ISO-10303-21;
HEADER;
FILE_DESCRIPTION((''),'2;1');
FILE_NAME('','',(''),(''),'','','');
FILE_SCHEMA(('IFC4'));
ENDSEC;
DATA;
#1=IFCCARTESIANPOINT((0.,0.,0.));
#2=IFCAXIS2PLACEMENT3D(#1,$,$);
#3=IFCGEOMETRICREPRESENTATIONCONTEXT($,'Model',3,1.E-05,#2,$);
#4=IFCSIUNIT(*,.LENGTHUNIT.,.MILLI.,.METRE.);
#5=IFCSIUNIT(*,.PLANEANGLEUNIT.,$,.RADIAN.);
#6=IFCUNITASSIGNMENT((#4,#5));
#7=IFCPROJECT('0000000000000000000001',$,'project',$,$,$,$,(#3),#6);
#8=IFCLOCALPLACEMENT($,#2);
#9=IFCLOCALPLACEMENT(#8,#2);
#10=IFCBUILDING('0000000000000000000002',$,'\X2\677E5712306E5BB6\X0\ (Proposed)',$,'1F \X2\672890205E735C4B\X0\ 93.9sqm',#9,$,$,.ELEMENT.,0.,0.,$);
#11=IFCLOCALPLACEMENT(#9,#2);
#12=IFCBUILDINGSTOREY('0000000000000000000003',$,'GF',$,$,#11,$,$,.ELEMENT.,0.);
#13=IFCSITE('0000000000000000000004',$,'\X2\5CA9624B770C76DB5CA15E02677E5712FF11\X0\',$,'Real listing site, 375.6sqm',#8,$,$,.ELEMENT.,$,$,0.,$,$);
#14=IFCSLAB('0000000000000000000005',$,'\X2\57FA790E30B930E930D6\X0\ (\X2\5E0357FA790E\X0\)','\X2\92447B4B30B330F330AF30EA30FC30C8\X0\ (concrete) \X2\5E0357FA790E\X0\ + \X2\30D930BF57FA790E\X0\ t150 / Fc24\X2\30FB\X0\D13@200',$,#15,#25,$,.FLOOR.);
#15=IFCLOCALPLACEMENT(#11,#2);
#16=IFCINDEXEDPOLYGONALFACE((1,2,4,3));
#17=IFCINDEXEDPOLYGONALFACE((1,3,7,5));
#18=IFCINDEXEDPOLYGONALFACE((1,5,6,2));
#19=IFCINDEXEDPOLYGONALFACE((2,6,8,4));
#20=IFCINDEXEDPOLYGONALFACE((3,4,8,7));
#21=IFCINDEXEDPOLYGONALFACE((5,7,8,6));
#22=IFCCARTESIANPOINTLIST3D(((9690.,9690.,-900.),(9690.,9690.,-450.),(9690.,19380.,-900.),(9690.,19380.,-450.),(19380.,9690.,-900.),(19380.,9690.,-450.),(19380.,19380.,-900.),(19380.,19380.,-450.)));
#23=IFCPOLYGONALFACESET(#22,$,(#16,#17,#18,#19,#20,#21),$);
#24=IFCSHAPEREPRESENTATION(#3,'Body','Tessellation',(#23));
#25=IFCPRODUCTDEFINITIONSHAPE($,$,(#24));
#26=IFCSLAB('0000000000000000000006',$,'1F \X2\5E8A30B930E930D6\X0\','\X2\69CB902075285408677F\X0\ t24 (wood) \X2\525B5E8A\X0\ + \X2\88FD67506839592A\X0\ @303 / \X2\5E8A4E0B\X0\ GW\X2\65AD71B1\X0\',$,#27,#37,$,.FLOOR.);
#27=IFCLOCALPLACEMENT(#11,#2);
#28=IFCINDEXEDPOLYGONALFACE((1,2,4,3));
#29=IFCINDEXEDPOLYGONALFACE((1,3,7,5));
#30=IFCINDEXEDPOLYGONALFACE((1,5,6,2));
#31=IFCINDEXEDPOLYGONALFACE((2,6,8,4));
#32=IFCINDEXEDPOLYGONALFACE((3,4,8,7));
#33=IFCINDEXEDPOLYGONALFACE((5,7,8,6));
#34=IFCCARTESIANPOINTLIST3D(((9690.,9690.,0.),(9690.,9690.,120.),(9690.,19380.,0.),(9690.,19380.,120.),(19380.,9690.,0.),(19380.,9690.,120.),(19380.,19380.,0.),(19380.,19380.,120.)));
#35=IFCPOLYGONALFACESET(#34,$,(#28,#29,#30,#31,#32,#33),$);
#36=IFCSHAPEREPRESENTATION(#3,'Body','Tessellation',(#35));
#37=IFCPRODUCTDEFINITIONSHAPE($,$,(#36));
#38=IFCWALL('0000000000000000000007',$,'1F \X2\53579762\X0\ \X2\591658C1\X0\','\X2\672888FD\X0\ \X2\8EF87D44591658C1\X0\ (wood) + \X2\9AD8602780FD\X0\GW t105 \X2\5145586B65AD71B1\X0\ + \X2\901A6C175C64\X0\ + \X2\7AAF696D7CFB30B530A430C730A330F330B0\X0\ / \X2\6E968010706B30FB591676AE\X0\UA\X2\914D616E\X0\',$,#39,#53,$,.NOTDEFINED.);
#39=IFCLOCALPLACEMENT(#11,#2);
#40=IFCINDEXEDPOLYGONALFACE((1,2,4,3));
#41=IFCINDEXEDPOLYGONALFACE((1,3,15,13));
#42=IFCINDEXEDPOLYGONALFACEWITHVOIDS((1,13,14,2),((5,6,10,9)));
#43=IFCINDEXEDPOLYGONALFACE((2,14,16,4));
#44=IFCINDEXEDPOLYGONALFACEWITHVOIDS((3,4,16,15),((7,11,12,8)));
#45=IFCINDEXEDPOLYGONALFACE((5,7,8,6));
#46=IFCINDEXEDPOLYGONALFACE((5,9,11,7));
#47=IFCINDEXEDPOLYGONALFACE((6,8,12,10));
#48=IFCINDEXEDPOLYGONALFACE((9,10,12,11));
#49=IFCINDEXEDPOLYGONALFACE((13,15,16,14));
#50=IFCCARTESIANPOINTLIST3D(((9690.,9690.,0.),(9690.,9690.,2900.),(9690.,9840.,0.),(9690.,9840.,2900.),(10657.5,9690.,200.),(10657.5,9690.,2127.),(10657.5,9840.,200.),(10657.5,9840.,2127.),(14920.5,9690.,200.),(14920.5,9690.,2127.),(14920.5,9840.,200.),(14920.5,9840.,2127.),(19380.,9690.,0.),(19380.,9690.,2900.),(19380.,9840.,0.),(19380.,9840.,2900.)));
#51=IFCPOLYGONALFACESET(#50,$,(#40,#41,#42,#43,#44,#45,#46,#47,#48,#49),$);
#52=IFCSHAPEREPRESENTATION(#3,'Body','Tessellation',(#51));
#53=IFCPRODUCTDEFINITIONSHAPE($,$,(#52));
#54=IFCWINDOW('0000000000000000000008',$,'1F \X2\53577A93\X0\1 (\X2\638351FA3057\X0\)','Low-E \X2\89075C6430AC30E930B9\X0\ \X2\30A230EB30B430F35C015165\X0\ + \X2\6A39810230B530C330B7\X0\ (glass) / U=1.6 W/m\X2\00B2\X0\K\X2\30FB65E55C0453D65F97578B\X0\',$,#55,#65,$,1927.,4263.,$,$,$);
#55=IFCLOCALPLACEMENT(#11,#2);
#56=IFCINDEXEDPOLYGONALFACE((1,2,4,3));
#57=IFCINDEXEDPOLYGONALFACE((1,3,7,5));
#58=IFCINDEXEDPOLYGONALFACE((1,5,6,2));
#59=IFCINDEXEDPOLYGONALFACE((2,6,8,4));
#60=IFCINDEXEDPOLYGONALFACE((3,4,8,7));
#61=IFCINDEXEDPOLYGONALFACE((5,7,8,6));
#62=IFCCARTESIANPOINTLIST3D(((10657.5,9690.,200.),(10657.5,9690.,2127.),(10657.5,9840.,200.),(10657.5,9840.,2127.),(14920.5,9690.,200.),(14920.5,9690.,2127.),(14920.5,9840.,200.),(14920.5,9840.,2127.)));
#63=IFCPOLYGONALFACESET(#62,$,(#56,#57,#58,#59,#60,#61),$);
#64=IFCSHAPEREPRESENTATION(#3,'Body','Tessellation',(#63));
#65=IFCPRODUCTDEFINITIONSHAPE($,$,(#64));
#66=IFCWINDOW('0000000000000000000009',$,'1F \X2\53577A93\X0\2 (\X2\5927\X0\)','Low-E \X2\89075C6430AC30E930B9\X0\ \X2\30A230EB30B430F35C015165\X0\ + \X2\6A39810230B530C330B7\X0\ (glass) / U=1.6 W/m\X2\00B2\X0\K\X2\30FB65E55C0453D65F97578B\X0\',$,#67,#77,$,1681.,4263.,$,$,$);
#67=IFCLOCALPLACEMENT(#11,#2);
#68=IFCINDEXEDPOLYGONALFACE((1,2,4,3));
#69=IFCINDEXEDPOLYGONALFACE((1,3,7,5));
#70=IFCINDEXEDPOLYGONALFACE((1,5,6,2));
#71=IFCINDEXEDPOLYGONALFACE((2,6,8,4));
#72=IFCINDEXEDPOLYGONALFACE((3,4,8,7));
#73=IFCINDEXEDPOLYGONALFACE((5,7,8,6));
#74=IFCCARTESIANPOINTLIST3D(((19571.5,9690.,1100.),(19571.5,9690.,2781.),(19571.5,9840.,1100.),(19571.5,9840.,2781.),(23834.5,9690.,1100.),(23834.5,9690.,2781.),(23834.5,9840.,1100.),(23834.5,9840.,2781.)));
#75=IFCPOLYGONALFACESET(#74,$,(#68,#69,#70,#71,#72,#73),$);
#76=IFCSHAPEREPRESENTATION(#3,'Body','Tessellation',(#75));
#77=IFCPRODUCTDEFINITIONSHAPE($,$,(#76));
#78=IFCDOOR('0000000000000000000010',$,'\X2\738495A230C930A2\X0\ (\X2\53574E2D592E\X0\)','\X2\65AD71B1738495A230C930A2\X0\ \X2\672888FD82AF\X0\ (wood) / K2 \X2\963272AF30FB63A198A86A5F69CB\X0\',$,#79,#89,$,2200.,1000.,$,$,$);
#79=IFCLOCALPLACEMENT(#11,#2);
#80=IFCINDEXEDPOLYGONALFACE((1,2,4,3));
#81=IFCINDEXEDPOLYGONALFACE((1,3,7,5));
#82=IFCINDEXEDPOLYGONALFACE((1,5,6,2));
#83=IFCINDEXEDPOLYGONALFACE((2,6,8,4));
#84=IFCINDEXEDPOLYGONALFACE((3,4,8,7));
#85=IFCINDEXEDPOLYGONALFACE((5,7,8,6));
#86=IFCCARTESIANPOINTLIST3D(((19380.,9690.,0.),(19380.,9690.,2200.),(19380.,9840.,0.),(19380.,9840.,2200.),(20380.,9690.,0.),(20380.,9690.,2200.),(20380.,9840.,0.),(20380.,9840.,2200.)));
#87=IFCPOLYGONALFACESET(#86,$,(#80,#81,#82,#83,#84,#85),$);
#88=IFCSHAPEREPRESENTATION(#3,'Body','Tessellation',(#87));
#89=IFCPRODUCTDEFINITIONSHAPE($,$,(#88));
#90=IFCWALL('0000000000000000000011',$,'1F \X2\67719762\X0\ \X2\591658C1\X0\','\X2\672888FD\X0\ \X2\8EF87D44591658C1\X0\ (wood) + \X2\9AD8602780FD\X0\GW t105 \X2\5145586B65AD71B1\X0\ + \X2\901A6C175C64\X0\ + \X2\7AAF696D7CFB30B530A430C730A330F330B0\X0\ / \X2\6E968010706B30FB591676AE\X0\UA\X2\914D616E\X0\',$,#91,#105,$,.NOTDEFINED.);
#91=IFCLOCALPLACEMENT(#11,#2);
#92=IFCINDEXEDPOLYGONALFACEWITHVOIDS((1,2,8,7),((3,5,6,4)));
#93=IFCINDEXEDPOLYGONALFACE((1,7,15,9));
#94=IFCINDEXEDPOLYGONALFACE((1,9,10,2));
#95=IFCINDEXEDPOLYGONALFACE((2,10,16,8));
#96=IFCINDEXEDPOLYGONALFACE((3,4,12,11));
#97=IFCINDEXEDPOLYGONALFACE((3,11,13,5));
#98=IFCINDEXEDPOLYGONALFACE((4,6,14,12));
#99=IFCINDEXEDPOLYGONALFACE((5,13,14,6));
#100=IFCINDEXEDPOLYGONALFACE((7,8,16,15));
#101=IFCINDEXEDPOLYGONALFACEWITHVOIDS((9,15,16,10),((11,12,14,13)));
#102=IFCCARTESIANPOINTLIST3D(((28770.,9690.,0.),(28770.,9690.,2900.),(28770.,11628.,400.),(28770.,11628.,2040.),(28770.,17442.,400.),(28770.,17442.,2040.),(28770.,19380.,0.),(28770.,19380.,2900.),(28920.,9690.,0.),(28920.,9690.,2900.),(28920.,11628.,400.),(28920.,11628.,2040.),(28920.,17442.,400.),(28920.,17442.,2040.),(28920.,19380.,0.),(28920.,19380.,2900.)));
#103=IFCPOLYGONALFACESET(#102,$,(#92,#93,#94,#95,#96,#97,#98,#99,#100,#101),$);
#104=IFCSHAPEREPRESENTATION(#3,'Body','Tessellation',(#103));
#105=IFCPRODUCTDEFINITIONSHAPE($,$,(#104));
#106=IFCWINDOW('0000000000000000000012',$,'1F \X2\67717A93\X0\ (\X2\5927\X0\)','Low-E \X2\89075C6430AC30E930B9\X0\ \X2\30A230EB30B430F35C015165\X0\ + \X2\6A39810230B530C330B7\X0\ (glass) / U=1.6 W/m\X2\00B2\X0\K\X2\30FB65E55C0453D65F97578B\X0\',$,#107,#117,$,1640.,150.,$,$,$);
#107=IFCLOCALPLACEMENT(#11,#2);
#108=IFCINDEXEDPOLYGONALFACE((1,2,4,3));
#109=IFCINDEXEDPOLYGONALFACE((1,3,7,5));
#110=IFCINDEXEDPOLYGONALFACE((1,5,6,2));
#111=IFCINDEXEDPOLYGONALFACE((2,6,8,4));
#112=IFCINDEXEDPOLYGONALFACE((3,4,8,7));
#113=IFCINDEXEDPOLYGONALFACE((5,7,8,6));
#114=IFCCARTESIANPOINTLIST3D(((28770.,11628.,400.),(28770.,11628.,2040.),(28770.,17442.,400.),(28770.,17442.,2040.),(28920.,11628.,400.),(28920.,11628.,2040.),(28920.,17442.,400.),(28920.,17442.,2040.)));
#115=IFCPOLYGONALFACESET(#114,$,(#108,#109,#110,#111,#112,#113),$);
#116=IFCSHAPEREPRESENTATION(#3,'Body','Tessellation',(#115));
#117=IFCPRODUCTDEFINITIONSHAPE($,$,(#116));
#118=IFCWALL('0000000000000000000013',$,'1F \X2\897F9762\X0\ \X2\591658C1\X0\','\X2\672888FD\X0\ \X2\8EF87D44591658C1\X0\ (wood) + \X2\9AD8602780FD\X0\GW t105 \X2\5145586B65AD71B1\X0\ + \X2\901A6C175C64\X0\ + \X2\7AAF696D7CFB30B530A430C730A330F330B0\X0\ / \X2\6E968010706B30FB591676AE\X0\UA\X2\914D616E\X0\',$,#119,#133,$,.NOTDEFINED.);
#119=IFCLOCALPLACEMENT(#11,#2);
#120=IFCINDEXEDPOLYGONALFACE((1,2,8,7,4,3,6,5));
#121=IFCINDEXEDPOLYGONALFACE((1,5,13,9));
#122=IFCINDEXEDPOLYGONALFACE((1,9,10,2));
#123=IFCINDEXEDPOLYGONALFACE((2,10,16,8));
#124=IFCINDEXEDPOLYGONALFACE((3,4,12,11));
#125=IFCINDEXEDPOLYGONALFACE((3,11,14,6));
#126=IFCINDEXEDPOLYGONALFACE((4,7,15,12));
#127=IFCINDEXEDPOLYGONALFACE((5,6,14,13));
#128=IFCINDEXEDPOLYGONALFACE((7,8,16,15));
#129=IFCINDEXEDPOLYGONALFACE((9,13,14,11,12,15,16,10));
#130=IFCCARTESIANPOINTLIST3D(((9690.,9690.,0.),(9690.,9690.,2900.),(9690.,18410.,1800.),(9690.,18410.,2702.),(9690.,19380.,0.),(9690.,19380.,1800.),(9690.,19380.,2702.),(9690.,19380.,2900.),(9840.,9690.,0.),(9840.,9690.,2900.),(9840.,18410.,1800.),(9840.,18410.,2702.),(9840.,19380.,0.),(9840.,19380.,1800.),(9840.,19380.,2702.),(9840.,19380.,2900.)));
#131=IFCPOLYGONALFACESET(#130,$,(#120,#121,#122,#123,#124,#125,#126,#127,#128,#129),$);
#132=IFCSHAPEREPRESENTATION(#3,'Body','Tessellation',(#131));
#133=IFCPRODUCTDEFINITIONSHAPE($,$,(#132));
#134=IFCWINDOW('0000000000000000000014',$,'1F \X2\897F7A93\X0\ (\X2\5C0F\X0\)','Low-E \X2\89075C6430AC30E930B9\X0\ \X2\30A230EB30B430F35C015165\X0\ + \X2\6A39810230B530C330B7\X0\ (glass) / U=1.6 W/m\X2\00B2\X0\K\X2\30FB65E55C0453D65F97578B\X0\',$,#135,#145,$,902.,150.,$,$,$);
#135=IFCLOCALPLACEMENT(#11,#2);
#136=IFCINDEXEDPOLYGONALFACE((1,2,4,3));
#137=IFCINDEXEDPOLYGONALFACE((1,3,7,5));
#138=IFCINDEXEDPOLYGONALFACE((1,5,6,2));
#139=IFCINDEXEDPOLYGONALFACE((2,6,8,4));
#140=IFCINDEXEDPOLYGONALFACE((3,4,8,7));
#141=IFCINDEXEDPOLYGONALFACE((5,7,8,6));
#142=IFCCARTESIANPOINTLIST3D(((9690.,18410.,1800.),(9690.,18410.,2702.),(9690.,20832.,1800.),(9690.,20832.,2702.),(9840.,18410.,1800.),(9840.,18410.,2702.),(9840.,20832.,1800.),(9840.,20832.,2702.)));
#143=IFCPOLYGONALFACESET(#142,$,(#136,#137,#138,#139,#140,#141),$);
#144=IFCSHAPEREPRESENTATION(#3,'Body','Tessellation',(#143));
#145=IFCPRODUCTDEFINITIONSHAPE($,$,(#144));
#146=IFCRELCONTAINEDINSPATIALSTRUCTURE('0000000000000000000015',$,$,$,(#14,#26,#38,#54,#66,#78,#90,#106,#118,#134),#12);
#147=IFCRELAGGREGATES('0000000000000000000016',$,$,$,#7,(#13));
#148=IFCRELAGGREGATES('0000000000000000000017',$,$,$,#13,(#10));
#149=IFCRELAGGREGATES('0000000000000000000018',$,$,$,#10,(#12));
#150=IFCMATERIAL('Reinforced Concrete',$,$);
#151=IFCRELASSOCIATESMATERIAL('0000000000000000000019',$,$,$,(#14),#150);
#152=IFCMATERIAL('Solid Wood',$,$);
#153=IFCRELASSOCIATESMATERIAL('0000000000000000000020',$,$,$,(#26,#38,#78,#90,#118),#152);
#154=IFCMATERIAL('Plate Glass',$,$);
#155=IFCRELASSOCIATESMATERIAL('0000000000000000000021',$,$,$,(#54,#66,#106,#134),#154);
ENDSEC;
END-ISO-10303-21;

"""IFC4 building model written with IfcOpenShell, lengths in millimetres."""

from ifc_helpers import new_model, si_unit, frame, frame_2d, origin, place, context, project, spatial, rectangle, extrude, material, element, fill, save


model = new_model("IFC4")

# Units and contexts
model_context = context("Model", 3, precision=1e-05, world=origin())
ifc_project = project(units=[si_unit("LENGTHUNIT", "METRE", prefix="MILLI"), si_unit("PLANEANGLEUNIT", "RADIAN")], contexts=[model_context])

# Site, building, storey
site_placement = place(None, origin())
site = spatial("IfcSite", under=ifc_project, at=site_placement, Name="岩手県盛岡市松園１", ObjectType="Real listing site, 375.6sqm", CompositionType="ELEMENT", RefElevation=0.0)
building_placement = place(site_placement, origin())
building = spatial("IfcBuilding", under=site, at=building_placement, Name="松園の家 (Proposed)", ObjectType="1F 木造平屋 93.9sqm", CompositionType="ELEMENT", ElevationOfRefHeight=0.0, ElevationOfTerrain=0.0)
storey_placement = place(building_placement, origin())
storey = spatial("IfcBuildingStorey", under=building, at=storey_placement, Name="GF", CompositionType="ELEMENT", Elevation=0.0)

# Slabs
ifc_material_1 = material(Name="Reinforced Concrete")
slab_1_placement = place(storey_placement, frame((4845.0, 4845.0, -450.0)))
element("IfcSlab", 1, at=slab_1_placement, inside=storey, material=ifc_material_1, Name="基礎スラブ (布基礎)", Description="鉄筋コンクリート (concrete) 布基礎 + ベタ基礎 t150 / Fc24・D13@200", PredefinedType="FLOOR", context=model_context, shape_type="SweptSolid", body=[
    extrude(rectangle(XDim=9690.0, YDim=9690.0, at=frame_2d((4845.0, 4845.0))), frame((4845.0, 4845.0, -450.0)), (0.0, 0.0, 1.0), 450.0),
])
ifc_material_2 = material(Name="Solid Wood")
slab_2_placement = place(storey_placement, frame((4845.0, 4845.0, 0.0)))
element("IfcSlab", 2, at=slab_2_placement, inside=storey, material=ifc_material_2, Name="1F 床スラブ", Description="構造用合板 t24 (wood) 剛床 + 製材根太 @303 / 床下 GW断熱", PredefinedType="FLOOR", context=model_context, shape_type="SweptSolid", body=[
    extrude(rectangle(XDim=9690.0, YDim=9690.0, at=frame_2d((4845.0, 4845.0))), frame((4845.0, 4845.0, 0.0)), (0.0, 0.0, 1.0), 120.0),
])

# Wall, openings, windows, door
wall_1_placement = place(storey_placement, frame((4845.0, 4845.0, 0.0)))
wall_1 = element("IfcWall", 3, at=wall_1_placement, inside=storey, material=ifc_material_2, Name="1F 南面 外壁", Description="木製 軸組外壁 (wood) + 高性能GW t105 充填断熱 + 通気層 + 窯業系サイディング / 準耐火・外皮UA配慮", PredefinedType="NOTDEFINED", context=model_context, shape_type="SweptSolid", body=[
    extrude(rectangle(XDim=9690.0, YDim=150.0, at=frame_2d((4845.0, 75.0))), frame((4845.0, 4845.0, 0.0)), (0.0, 0.0, 1.0), 2900.0),
])
opening_1_placement = place(storey_placement, frame((5329.0, 4845.0, 100.0)))
opening_1 = element("IfcOpeningElement", 4, at=opening_1_placement, cuts=wall_1, PredefinedType="NOTDEFINED", context=model_context, shape_type="SweptSolid", body=[
    extrude(rectangle(XDim=4263.0, YDim=150.0, at=frame_2d((2131.0, 75.0))), frame((5329.0, 4845.0, 100.0)), (0.0, 0.0, 1.0), 1927.0),
])
opening_2_placement = place(storey_placement, frame((9786.0, 4845.0, 550.0)))
opening_2 = element("IfcOpeningElement", 5, at=opening_2_placement, cuts=wall_1, PredefinedType="NOTDEFINED", context=model_context, shape_type="SweptSolid", body=[
    extrude(rectangle(XDim=4263.0, YDim=150.0, at=frame_2d((2131.0, 75.0))), frame((9786.0, 4845.0, 550.0)), (0.0, 0.0, 1.0), 1681.0),
])
opening_3_placement = place(storey_placement, frame((9690.0, 4845.0, 0.0)))
opening_3 = element("IfcOpeningElement", 6, at=opening_3_placement, cuts=wall_1, PredefinedType="NOTDEFINED", context=model_context, shape_type="SweptSolid", body=[
    extrude(rectangle(XDim=1000.0, YDim=150.0, at=frame_2d((500.0, 75.0))), frame((9690.0, 4845.0, 0.0)), (0.0, 0.0, 1.0), 2200.0),
])
ifc_material_3 = material(Name="Plate Glass")
window_1_placement = place(storey_placement, frame((5329.0, 4845.0, 100.0)))
window_1 = element("IfcWindow", 7, at=window_1_placement, inside=storey, material=ifc_material_3, Name="1F 南窓1 (掃出し)", Description="Low-E 複層ガラス アルゴン封入 + 樹脂サッシ (glass) / U=1.6 W/m²K・日射取得型", OverallHeight=1927.0, OverallWidth=4263.0, context=model_context, shape_type="SweptSolid", body=[
    extrude(rectangle(XDim=4263.0, YDim=150.0, at=frame_2d((2131.0, 75.0))), frame((5329.0, 4845.0, 100.0)), (0.0, 0.0, 1.0), 1927.0),
])
fill(opening_1, window_1)
window_2_placement = place(storey_placement, frame((9786.0, 4845.0, 550.0)))
window_2 = element("IfcWindow", 8, at=window_2_placement, inside=storey, material=ifc_material_3, Name="1F 南窓2 (大)", Description="Low-E 複層ガラス アルゴン封入 + 樹脂サッシ (glass) / U=1.6 W/m²K・日射取得型", OverallHeight=1681.0, OverallWidth=4263.0, context=model_context, shape_type="SweptSolid", body=[
    extrude(rectangle(XDim=4263.0, YDim=150.0, at=frame_2d((2131.0, 75.0))), frame((9786.0, 4845.0, 550.0)), (0.0, 0.0, 1.0), 1681.0),
])
fill(opening_2, window_2)
door_placement = place(storey_placement, frame((9690.0, 4845.0, 0.0)))
door = element("IfcDoor", 9, at=door_placement, inside=storey, material=ifc_material_2, Name="玄関ドア (南中央)", Description="断熱玄関ドア 木製芯 (wood) / K2 防犯・採風機構", OverallHeight=2200.0, OverallWidth=1000.0, context=model_context, shape_type="SweptSolid", body=[
    extrude(rectangle(XDim=1000.0, YDim=150.0, at=frame_2d((500.0, 75.0))), frame((9690.0, 4845.0, 0.0)), (0.0, 0.0, 1.0), 2200.0),
])
fill(opening_3, door)

# Walls, openings, windows
wall_2_placement = place(storey_placement, frame((14385.0, 4845.0, 0.0)))
wall_2 = element("IfcWall", 10, at=wall_2_placement, inside=storey, material=ifc_material_2, Name="1F 東面 外壁", Description="木製 軸組外壁 (wood) + 高性能GW t105 充填断熱 + 通気層 + 窯業系サイディング / 準耐火・外皮UA配慮", PredefinedType="NOTDEFINED", context=model_context, shape_type="SweptSolid", body=[
    extrude(rectangle(XDim=150.0, YDim=9690.0, at=frame_2d((75.0, 4845.0))), frame((14385.0, 4845.0, 0.0)), (0.0, 0.0, 1.0), 2900.0),
])
opening_4_placement = place(storey_placement, frame((14385.0, 5814.0, 200.0)))
opening_4 = element("IfcOpeningElement", 11, at=opening_4_placement, cuts=wall_2, PredefinedType="NOTDEFINED", context=model_context, shape_type="SweptSolid", body=[
    extrude(rectangle(XDim=150.0, YDim=5814.0, at=frame_2d((75.0, 2907.0))), frame((14385.0, 5814.0, 200.0)), (0.0, 0.0, 1.0), 1640.0),
])
window_3_placement = place(storey_placement, frame((14385.0, 5814.0, 200.0)))
window_3 = element("IfcWindow", 12, at=window_3_placement, inside=storey, material=ifc_material_3, Name="1F 東窓 (大)", Description="Low-E 複層ガラス アルゴン封入 + 樹脂サッシ (glass) / U=1.6 W/m²K・日射取得型", OverallHeight=1640.0, OverallWidth=150.0, context=model_context, shape_type="SweptSolid", body=[
    extrude(rectangle(XDim=150.0, YDim=5814.0, at=frame_2d((75.0, 2907.0))), frame((14385.0, 5814.0, 200.0)), (0.0, 0.0, 1.0), 1640.0),
])
fill(opening_4, window_3)
wall_3_placement = place(storey_placement, frame((4845.0, 4845.0, 0.0)))
wall_3 = element("IfcWall", 13, at=wall_3_placement, inside=storey, material=ifc_material_2, Name="1F 西面 外壁", Description="木製 軸組外壁 (wood) + 高性能GW t105 充填断熱 + 通気層 + 窯業系サイディング / 準耐火・外皮UA配慮", PredefinedType="NOTDEFINED", context=model_context, shape_type="SweptSolid", body=[
    extrude(rectangle(XDim=150.0, YDim=9690.0, at=frame_2d((75.0, 4845.0))), frame((4845.0, 4845.0, 0.0)), (0.0, 0.0, 1.0), 2900.0),
])
opening_5_placement = place(storey_placement, frame((4845.0, 9205.0, 900.0)))
opening_5 = element("IfcOpeningElement", 14, at=opening_5_placement, cuts=wall_3, PredefinedType="NOTDEFINED", context=model_context, shape_type="SweptSolid", body=[
    extrude(rectangle(XDim=150.0, YDim=2422.0, at=frame_2d((75.0, 1211.0))), frame((4845.0, 9205.0, 900.0)), (0.0, 0.0, 1.0), 902.0),
])
window_4_placement = place(storey_placement, frame((4845.0, 9205.0, 900.0)))
window_4 = element("IfcWindow", 15, at=window_4_placement, inside=storey, material=ifc_material_3, Name="1F 西窓 (小)", Description="Low-E 複層ガラス アルゴン封入 + 樹脂サッシ (glass) / U=1.6 W/m²K・日射取得型", OverallHeight=902.0, OverallWidth=150.0, context=model_context, shape_type="SweptSolid", body=[
    extrude(rectangle(XDim=150.0, YDim=2422.0, at=frame_2d((75.0, 1211.0))), frame((4845.0, 9205.0, 900.0)), (0.0, 0.0, 1.0), 902.0),
])
fill(opening_5, window_4)

save(model, "model.ifc")
